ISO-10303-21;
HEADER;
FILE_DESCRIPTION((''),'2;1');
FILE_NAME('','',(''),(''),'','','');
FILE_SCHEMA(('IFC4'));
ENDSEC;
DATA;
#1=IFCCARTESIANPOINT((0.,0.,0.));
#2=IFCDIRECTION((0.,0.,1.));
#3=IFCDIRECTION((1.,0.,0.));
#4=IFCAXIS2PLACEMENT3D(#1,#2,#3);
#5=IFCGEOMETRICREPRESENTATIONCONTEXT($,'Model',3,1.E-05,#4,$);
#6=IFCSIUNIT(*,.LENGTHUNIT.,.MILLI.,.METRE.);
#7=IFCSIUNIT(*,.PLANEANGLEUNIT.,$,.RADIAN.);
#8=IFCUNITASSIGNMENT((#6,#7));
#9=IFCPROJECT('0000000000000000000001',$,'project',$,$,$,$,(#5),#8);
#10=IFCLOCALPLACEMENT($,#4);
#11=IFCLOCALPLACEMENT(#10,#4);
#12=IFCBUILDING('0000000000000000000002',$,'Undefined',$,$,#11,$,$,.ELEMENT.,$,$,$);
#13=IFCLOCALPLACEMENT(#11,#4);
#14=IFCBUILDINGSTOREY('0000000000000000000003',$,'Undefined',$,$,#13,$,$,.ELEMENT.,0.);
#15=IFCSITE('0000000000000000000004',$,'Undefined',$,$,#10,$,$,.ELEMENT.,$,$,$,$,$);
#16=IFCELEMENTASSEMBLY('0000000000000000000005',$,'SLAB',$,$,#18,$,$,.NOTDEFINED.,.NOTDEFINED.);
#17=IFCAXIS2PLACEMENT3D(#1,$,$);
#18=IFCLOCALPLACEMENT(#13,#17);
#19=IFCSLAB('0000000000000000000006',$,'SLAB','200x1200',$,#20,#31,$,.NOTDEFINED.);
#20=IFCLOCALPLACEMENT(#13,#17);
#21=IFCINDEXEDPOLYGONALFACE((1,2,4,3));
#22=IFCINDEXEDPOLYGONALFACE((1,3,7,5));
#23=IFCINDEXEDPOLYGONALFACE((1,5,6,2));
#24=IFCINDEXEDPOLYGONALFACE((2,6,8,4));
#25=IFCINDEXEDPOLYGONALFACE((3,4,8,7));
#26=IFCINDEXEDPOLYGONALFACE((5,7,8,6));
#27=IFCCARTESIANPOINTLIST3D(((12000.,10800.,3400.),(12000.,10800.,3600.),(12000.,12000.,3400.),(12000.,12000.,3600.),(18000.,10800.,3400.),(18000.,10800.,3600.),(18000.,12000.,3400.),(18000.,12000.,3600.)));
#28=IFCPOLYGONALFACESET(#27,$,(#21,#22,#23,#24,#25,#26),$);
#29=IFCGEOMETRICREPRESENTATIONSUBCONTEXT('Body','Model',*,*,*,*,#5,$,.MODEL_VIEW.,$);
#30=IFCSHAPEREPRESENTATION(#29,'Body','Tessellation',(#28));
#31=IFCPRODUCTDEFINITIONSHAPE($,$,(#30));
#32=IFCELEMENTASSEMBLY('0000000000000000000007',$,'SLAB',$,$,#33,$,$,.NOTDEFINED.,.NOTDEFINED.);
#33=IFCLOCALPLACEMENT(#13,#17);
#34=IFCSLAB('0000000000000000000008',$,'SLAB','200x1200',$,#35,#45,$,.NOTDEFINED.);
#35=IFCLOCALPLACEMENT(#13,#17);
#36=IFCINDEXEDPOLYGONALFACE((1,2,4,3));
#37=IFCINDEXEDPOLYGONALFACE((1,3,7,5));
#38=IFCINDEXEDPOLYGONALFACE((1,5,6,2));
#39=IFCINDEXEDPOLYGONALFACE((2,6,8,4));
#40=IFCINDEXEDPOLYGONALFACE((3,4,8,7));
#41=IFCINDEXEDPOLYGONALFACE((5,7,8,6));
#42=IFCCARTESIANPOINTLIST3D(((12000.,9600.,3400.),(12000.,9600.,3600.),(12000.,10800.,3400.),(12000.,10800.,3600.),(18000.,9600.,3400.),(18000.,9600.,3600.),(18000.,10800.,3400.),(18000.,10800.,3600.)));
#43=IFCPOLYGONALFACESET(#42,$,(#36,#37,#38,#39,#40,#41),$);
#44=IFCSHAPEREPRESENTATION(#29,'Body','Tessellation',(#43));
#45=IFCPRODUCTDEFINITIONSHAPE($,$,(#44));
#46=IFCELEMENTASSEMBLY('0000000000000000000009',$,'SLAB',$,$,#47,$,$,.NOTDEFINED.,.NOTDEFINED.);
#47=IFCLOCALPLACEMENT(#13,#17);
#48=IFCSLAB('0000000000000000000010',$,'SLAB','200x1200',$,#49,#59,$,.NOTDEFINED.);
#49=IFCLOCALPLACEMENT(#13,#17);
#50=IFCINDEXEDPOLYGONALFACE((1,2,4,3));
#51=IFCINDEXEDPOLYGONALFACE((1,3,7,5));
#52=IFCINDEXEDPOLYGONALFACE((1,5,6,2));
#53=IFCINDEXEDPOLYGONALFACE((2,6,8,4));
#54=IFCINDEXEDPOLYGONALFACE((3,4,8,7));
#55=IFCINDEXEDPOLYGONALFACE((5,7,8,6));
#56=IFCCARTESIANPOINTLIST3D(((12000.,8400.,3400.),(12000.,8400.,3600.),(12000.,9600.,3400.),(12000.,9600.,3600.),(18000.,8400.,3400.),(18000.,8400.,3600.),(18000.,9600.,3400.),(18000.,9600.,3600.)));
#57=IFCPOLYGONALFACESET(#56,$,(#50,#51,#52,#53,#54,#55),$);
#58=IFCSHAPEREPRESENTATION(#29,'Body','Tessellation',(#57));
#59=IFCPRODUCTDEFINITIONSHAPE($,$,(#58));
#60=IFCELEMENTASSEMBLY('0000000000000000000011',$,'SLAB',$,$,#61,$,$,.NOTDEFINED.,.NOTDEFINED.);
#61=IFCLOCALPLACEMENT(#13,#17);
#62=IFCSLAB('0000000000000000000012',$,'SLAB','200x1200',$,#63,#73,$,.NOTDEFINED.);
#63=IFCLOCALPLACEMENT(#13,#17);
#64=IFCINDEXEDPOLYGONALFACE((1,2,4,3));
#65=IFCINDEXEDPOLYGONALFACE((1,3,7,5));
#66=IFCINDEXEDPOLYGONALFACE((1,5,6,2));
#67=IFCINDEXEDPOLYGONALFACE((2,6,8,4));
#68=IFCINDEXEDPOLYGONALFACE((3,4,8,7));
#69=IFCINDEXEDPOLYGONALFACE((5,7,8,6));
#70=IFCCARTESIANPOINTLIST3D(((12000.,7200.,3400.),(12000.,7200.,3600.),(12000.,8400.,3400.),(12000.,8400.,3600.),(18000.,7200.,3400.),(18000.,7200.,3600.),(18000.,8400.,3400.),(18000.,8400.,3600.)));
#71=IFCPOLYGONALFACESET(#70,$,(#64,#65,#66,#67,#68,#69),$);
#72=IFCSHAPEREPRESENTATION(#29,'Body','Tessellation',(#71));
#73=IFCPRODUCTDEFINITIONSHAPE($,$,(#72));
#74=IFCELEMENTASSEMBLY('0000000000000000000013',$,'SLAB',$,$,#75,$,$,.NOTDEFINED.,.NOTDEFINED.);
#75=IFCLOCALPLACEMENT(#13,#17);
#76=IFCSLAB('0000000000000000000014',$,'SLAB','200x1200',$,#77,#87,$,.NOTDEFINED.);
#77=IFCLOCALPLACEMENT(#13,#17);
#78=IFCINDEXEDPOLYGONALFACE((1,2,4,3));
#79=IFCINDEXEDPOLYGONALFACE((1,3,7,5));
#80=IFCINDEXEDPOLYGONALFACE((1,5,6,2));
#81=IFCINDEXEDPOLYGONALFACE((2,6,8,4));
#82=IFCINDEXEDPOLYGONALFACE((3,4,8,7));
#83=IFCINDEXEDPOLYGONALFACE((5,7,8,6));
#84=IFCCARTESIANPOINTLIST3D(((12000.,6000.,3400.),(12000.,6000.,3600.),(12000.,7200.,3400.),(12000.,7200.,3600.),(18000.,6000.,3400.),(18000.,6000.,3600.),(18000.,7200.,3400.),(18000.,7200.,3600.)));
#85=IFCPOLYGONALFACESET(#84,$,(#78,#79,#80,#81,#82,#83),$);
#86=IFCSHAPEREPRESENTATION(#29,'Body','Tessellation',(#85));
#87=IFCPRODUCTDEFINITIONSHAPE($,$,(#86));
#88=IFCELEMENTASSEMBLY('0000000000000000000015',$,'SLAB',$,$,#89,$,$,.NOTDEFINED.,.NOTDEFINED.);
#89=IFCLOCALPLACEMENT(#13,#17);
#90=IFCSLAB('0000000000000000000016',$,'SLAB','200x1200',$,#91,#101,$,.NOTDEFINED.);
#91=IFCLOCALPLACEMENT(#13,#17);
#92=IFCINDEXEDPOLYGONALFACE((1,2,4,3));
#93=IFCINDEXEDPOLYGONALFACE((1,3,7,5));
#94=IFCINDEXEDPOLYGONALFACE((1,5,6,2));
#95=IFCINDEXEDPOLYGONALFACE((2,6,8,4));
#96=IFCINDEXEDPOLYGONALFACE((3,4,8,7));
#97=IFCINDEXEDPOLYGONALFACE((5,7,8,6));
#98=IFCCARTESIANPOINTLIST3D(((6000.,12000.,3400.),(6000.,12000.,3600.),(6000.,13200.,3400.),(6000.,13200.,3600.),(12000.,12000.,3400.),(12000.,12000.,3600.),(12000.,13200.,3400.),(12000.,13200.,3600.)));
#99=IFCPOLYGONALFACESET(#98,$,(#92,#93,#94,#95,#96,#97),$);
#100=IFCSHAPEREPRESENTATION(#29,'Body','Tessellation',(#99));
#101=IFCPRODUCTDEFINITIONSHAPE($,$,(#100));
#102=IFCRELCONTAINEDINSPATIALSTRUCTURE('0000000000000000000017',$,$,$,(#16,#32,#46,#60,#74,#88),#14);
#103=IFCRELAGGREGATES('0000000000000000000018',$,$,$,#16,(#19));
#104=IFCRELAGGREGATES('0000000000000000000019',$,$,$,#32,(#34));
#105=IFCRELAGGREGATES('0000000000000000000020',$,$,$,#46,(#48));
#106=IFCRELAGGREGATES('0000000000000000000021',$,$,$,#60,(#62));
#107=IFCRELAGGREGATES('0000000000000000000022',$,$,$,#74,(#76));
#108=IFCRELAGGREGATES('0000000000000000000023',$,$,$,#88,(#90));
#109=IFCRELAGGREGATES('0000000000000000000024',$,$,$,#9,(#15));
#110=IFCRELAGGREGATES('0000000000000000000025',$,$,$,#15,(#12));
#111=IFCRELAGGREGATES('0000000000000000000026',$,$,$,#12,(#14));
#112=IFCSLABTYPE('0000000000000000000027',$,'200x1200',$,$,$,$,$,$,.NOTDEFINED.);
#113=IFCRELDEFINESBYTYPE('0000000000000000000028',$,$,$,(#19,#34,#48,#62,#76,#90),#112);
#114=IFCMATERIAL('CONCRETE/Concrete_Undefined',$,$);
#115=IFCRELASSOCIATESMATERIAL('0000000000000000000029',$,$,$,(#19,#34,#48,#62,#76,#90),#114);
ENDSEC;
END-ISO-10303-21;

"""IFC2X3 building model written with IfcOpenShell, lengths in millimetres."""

from ifc_helpers import new_model, si_unit, frame, origin_with_axes, place, context, subcontext, project, spatial, polyline, outline, extrude, material, type_object, element, aggregate, save


model = new_model("IFC2X3")

# Units and contexts
model_context = context("Model", 3, precision=1e-05, world=origin_with_axes())
body_context = subcontext(model_context, "Body", "Model", "MODEL_VIEW")
ifc_project = project(units=[si_unit("LENGTHUNIT", "METRE", prefix="MILLI"), si_unit("PLANEANGLEUNIT", "RADIAN")], contexts=[model_context])

# Site, building, storey
site_placement = place(None, origin_with_axes())
site = spatial("IfcSite", under=ifc_project, at=site_placement, Name="Undefined", CompositionType="ELEMENT")
building_placement = place(site_placement, origin_with_axes())
building = spatial("IfcBuilding", under=site, at=building_placement, Name="Undefined", CompositionType="ELEMENT")
storey_placement = place(building_placement, origin_with_axes())
storey = spatial("IfcBuildingStorey", under=building, at=storey_placement, Name="Undefined", CompositionType="ELEMENT", Elevation=0.0)

# Shared definitions
ifc_material_1 = material(Name="CONCRETE/Concrete_Undefined")

# Element assemblies, slabs
slab_type = type_object("IfcSlabType", Name="200x1200", PredefinedType="NOTDEFINED")
assembly_1_placement = place(storey_placement, origin_with_axes())
assembly_1 = element("IfcElementAssembly", 1, at=assembly_1_placement, inside=storey, Name="SLAB", AssemblyPlace="NOTDEFINED", PredefinedType="NOTDEFINED")
slab_1_placement = place(assembly_1_placement, frame((18000.0, 10800.0, 3500.0), z_axis=(0.0, 0.0, 1.0), x_axis=(0.0, 1.0, 0.0)))
slab_1 = element("IfcSlab", 2, at=slab_1_placement, type_object=slab_type, material=ifc_material_1, Name="SLAB", Description="200x1200", PredefinedType="NOTDEFINED", context=body_context, shape_type="SweptSolid", body=[
    extrude(outline(polyline([(0.0, 0.0), (1200.0, 0.0), (1200.0, 6000.0), (0.0, 6000.0), (0.0, 0.0)])), frame((0.0, 0.0, -100.0), z_axis=(0.0, 0.0, 1.0), x_axis=(1.0, 0.0, 0.0)), (0.0, 0.0, 1.0), 200.0),
])
aggregate(assembly_1, [slab_1])
assembly_2_placement = place(storey_placement, origin_with_axes())
assembly_2 = element("IfcElementAssembly", 3, at=assembly_2_placement, inside=storey, Name="SLAB", AssemblyPlace="NOTDEFINED", PredefinedType="NOTDEFINED")
slab_2_placement = place(assembly_2_placement, frame((18000.0, 9600.0, 3500.0), z_axis=(0.0, 0.0, 1.0), x_axis=(0.0, 1.0, 0.0)))
slab_2 = element("IfcSlab", 4, at=slab_2_placement, type_object=slab_type, material=ifc_material_1, Name="SLAB", Description="200x1200", PredefinedType="NOTDEFINED", context=body_context, shape_type="SweptSolid", body=[
    extrude(outline(polyline([(0.0, 0.0), (1200.0, 0.0), (1200.0, 6000.0), (0.0, 6000.0), (0.0, 0.0)])), frame((0.0, 0.0, -100.0), z_axis=(0.0, 0.0, 1.0), x_axis=(1.0, 0.0, 0.0)), (0.0, 0.0, 1.0), 200.0),
])
aggregate(assembly_2, [slab_2])
assembly_3_placement = place(storey_placement, origin_with_axes())
assembly_3 = element("IfcElementAssembly", 5, at=assembly_3_placement, inside=storey, Name="SLAB", AssemblyPlace="NOTDEFINED", PredefinedType="NOTDEFINED")
slab_3_placement = place(assembly_3_placement, frame((18000.0, 8400.0, 3500.0), z_axis=(0.0, 0.0, 1.0), x_axis=(0.0, 1.0, 0.0)))
slab_3 = element("IfcSlab", 6, at=slab_3_placement, type_object=slab_type, material=ifc_material_1, Name="SLAB", Description="200x1200", PredefinedType="NOTDEFINED", context=body_context, shape_type="SweptSolid", body=[
    extrude(outline(polyline([(0.0, 0.0), (1200.0, 0.0), (1200.0, 6000.0), (0.0, 6000.0), (0.0, 0.0)])), frame((0.0, 0.0, -100.0), z_axis=(0.0, 0.0, 1.0), x_axis=(1.0, 0.0, 0.0)), (0.0, 0.0, 1.0), 200.0),
])
aggregate(assembly_3, [slab_3])
assembly_4_placement = place(storey_placement, origin_with_axes())
assembly_4 = element("IfcElementAssembly", 7, at=assembly_4_placement, inside=storey, Name="SLAB", AssemblyPlace="NOTDEFINED", PredefinedType="NOTDEFINED")
slab_4_placement = place(assembly_4_placement, frame((18000.0, 7200.0, 3500.0), z_axis=(0.0, 0.0, 1.0), x_axis=(0.0, 1.0, 0.0)))
slab_4 = element("IfcSlab", 8, at=slab_4_placement, type_object=slab_type, material=ifc_material_1, Name="SLAB", Description="200x1200", PredefinedType="NOTDEFINED", context=body_context, shape_type="SweptSolid", body=[
    extrude(outline(polyline([(0.0, 0.0), (1200.0, 0.0), (1200.0, 6000.0), (0.0, 6000.0), (0.0, 0.0)])), frame((0.0, 0.0, -100.0), z_axis=(0.0, 0.0, 1.0), x_axis=(1.0, 0.0, 0.0)), (0.0, 0.0, 1.0), 200.0),
])
aggregate(assembly_4, [slab_4])
assembly_5_placement = place(storey_placement, origin_with_axes())
assembly_5 = element("IfcElementAssembly", 9, at=assembly_5_placement, inside=storey, Name="SLAB", AssemblyPlace="NOTDEFINED", PredefinedType="NOTDEFINED")
slab_5_placement = place(assembly_5_placement, frame((18000.0, 6000.0, 3500.0), z_axis=(0.0, 0.0, 1.0), x_axis=(0.0, 1.0, 0.0)))
slab_5 = element("IfcSlab", 10, at=slab_5_placement, type_object=slab_type, material=ifc_material_1, Name="SLAB", Description="200x1200", PredefinedType="NOTDEFINED", context=body_context, shape_type="SweptSolid", body=[
    extrude(outline(polyline([(0.0, 0.0), (1200.0, 0.0), (1200.0, 6000.0), (0.0, 6000.0), (0.0, 0.0)])), frame((0.0, 0.0, -100.0), z_axis=(0.0, 0.0, 1.0), x_axis=(1.0, 0.0, 0.0)), (0.0, 0.0, 1.0), 200.0),
])
aggregate(assembly_5, [slab_5])
assembly_6_placement = place(storey_placement, origin_with_axes())
assembly_6 = element("IfcElementAssembly", 11, at=assembly_6_placement, inside=storey, Name="SLAB", AssemblyPlace="NOTDEFINED", PredefinedType="NOTDEFINED")
slab_6_placement = place(assembly_6_placement, frame((12000.0, 12000.0, 3500.0), z_axis=(0.0, 0.0, 1.0), x_axis=(0.0, 1.0, 0.0)))
slab_6 = element("IfcSlab", 12, at=slab_6_placement, type_object=slab_type, material=ifc_material_1, Name="SLAB", Description="200x1200", PredefinedType="NOTDEFINED", context=body_context, shape_type="SweptSolid", body=[
    extrude(outline(polyline([(0.0, 0.0), (1200.0, 0.0), (1200.0, 6000.0), (0.0, 6000.0), (0.0, 0.0)])), frame((0.0, 0.0, -100.0), z_axis=(0.0, 0.0, 1.0), x_axis=(1.0, 0.0, 0.0)), (0.0, 0.0, 1.0), 200.0),
])
aggregate(assembly_6, [slab_6])

save(model, "model.ifc")
